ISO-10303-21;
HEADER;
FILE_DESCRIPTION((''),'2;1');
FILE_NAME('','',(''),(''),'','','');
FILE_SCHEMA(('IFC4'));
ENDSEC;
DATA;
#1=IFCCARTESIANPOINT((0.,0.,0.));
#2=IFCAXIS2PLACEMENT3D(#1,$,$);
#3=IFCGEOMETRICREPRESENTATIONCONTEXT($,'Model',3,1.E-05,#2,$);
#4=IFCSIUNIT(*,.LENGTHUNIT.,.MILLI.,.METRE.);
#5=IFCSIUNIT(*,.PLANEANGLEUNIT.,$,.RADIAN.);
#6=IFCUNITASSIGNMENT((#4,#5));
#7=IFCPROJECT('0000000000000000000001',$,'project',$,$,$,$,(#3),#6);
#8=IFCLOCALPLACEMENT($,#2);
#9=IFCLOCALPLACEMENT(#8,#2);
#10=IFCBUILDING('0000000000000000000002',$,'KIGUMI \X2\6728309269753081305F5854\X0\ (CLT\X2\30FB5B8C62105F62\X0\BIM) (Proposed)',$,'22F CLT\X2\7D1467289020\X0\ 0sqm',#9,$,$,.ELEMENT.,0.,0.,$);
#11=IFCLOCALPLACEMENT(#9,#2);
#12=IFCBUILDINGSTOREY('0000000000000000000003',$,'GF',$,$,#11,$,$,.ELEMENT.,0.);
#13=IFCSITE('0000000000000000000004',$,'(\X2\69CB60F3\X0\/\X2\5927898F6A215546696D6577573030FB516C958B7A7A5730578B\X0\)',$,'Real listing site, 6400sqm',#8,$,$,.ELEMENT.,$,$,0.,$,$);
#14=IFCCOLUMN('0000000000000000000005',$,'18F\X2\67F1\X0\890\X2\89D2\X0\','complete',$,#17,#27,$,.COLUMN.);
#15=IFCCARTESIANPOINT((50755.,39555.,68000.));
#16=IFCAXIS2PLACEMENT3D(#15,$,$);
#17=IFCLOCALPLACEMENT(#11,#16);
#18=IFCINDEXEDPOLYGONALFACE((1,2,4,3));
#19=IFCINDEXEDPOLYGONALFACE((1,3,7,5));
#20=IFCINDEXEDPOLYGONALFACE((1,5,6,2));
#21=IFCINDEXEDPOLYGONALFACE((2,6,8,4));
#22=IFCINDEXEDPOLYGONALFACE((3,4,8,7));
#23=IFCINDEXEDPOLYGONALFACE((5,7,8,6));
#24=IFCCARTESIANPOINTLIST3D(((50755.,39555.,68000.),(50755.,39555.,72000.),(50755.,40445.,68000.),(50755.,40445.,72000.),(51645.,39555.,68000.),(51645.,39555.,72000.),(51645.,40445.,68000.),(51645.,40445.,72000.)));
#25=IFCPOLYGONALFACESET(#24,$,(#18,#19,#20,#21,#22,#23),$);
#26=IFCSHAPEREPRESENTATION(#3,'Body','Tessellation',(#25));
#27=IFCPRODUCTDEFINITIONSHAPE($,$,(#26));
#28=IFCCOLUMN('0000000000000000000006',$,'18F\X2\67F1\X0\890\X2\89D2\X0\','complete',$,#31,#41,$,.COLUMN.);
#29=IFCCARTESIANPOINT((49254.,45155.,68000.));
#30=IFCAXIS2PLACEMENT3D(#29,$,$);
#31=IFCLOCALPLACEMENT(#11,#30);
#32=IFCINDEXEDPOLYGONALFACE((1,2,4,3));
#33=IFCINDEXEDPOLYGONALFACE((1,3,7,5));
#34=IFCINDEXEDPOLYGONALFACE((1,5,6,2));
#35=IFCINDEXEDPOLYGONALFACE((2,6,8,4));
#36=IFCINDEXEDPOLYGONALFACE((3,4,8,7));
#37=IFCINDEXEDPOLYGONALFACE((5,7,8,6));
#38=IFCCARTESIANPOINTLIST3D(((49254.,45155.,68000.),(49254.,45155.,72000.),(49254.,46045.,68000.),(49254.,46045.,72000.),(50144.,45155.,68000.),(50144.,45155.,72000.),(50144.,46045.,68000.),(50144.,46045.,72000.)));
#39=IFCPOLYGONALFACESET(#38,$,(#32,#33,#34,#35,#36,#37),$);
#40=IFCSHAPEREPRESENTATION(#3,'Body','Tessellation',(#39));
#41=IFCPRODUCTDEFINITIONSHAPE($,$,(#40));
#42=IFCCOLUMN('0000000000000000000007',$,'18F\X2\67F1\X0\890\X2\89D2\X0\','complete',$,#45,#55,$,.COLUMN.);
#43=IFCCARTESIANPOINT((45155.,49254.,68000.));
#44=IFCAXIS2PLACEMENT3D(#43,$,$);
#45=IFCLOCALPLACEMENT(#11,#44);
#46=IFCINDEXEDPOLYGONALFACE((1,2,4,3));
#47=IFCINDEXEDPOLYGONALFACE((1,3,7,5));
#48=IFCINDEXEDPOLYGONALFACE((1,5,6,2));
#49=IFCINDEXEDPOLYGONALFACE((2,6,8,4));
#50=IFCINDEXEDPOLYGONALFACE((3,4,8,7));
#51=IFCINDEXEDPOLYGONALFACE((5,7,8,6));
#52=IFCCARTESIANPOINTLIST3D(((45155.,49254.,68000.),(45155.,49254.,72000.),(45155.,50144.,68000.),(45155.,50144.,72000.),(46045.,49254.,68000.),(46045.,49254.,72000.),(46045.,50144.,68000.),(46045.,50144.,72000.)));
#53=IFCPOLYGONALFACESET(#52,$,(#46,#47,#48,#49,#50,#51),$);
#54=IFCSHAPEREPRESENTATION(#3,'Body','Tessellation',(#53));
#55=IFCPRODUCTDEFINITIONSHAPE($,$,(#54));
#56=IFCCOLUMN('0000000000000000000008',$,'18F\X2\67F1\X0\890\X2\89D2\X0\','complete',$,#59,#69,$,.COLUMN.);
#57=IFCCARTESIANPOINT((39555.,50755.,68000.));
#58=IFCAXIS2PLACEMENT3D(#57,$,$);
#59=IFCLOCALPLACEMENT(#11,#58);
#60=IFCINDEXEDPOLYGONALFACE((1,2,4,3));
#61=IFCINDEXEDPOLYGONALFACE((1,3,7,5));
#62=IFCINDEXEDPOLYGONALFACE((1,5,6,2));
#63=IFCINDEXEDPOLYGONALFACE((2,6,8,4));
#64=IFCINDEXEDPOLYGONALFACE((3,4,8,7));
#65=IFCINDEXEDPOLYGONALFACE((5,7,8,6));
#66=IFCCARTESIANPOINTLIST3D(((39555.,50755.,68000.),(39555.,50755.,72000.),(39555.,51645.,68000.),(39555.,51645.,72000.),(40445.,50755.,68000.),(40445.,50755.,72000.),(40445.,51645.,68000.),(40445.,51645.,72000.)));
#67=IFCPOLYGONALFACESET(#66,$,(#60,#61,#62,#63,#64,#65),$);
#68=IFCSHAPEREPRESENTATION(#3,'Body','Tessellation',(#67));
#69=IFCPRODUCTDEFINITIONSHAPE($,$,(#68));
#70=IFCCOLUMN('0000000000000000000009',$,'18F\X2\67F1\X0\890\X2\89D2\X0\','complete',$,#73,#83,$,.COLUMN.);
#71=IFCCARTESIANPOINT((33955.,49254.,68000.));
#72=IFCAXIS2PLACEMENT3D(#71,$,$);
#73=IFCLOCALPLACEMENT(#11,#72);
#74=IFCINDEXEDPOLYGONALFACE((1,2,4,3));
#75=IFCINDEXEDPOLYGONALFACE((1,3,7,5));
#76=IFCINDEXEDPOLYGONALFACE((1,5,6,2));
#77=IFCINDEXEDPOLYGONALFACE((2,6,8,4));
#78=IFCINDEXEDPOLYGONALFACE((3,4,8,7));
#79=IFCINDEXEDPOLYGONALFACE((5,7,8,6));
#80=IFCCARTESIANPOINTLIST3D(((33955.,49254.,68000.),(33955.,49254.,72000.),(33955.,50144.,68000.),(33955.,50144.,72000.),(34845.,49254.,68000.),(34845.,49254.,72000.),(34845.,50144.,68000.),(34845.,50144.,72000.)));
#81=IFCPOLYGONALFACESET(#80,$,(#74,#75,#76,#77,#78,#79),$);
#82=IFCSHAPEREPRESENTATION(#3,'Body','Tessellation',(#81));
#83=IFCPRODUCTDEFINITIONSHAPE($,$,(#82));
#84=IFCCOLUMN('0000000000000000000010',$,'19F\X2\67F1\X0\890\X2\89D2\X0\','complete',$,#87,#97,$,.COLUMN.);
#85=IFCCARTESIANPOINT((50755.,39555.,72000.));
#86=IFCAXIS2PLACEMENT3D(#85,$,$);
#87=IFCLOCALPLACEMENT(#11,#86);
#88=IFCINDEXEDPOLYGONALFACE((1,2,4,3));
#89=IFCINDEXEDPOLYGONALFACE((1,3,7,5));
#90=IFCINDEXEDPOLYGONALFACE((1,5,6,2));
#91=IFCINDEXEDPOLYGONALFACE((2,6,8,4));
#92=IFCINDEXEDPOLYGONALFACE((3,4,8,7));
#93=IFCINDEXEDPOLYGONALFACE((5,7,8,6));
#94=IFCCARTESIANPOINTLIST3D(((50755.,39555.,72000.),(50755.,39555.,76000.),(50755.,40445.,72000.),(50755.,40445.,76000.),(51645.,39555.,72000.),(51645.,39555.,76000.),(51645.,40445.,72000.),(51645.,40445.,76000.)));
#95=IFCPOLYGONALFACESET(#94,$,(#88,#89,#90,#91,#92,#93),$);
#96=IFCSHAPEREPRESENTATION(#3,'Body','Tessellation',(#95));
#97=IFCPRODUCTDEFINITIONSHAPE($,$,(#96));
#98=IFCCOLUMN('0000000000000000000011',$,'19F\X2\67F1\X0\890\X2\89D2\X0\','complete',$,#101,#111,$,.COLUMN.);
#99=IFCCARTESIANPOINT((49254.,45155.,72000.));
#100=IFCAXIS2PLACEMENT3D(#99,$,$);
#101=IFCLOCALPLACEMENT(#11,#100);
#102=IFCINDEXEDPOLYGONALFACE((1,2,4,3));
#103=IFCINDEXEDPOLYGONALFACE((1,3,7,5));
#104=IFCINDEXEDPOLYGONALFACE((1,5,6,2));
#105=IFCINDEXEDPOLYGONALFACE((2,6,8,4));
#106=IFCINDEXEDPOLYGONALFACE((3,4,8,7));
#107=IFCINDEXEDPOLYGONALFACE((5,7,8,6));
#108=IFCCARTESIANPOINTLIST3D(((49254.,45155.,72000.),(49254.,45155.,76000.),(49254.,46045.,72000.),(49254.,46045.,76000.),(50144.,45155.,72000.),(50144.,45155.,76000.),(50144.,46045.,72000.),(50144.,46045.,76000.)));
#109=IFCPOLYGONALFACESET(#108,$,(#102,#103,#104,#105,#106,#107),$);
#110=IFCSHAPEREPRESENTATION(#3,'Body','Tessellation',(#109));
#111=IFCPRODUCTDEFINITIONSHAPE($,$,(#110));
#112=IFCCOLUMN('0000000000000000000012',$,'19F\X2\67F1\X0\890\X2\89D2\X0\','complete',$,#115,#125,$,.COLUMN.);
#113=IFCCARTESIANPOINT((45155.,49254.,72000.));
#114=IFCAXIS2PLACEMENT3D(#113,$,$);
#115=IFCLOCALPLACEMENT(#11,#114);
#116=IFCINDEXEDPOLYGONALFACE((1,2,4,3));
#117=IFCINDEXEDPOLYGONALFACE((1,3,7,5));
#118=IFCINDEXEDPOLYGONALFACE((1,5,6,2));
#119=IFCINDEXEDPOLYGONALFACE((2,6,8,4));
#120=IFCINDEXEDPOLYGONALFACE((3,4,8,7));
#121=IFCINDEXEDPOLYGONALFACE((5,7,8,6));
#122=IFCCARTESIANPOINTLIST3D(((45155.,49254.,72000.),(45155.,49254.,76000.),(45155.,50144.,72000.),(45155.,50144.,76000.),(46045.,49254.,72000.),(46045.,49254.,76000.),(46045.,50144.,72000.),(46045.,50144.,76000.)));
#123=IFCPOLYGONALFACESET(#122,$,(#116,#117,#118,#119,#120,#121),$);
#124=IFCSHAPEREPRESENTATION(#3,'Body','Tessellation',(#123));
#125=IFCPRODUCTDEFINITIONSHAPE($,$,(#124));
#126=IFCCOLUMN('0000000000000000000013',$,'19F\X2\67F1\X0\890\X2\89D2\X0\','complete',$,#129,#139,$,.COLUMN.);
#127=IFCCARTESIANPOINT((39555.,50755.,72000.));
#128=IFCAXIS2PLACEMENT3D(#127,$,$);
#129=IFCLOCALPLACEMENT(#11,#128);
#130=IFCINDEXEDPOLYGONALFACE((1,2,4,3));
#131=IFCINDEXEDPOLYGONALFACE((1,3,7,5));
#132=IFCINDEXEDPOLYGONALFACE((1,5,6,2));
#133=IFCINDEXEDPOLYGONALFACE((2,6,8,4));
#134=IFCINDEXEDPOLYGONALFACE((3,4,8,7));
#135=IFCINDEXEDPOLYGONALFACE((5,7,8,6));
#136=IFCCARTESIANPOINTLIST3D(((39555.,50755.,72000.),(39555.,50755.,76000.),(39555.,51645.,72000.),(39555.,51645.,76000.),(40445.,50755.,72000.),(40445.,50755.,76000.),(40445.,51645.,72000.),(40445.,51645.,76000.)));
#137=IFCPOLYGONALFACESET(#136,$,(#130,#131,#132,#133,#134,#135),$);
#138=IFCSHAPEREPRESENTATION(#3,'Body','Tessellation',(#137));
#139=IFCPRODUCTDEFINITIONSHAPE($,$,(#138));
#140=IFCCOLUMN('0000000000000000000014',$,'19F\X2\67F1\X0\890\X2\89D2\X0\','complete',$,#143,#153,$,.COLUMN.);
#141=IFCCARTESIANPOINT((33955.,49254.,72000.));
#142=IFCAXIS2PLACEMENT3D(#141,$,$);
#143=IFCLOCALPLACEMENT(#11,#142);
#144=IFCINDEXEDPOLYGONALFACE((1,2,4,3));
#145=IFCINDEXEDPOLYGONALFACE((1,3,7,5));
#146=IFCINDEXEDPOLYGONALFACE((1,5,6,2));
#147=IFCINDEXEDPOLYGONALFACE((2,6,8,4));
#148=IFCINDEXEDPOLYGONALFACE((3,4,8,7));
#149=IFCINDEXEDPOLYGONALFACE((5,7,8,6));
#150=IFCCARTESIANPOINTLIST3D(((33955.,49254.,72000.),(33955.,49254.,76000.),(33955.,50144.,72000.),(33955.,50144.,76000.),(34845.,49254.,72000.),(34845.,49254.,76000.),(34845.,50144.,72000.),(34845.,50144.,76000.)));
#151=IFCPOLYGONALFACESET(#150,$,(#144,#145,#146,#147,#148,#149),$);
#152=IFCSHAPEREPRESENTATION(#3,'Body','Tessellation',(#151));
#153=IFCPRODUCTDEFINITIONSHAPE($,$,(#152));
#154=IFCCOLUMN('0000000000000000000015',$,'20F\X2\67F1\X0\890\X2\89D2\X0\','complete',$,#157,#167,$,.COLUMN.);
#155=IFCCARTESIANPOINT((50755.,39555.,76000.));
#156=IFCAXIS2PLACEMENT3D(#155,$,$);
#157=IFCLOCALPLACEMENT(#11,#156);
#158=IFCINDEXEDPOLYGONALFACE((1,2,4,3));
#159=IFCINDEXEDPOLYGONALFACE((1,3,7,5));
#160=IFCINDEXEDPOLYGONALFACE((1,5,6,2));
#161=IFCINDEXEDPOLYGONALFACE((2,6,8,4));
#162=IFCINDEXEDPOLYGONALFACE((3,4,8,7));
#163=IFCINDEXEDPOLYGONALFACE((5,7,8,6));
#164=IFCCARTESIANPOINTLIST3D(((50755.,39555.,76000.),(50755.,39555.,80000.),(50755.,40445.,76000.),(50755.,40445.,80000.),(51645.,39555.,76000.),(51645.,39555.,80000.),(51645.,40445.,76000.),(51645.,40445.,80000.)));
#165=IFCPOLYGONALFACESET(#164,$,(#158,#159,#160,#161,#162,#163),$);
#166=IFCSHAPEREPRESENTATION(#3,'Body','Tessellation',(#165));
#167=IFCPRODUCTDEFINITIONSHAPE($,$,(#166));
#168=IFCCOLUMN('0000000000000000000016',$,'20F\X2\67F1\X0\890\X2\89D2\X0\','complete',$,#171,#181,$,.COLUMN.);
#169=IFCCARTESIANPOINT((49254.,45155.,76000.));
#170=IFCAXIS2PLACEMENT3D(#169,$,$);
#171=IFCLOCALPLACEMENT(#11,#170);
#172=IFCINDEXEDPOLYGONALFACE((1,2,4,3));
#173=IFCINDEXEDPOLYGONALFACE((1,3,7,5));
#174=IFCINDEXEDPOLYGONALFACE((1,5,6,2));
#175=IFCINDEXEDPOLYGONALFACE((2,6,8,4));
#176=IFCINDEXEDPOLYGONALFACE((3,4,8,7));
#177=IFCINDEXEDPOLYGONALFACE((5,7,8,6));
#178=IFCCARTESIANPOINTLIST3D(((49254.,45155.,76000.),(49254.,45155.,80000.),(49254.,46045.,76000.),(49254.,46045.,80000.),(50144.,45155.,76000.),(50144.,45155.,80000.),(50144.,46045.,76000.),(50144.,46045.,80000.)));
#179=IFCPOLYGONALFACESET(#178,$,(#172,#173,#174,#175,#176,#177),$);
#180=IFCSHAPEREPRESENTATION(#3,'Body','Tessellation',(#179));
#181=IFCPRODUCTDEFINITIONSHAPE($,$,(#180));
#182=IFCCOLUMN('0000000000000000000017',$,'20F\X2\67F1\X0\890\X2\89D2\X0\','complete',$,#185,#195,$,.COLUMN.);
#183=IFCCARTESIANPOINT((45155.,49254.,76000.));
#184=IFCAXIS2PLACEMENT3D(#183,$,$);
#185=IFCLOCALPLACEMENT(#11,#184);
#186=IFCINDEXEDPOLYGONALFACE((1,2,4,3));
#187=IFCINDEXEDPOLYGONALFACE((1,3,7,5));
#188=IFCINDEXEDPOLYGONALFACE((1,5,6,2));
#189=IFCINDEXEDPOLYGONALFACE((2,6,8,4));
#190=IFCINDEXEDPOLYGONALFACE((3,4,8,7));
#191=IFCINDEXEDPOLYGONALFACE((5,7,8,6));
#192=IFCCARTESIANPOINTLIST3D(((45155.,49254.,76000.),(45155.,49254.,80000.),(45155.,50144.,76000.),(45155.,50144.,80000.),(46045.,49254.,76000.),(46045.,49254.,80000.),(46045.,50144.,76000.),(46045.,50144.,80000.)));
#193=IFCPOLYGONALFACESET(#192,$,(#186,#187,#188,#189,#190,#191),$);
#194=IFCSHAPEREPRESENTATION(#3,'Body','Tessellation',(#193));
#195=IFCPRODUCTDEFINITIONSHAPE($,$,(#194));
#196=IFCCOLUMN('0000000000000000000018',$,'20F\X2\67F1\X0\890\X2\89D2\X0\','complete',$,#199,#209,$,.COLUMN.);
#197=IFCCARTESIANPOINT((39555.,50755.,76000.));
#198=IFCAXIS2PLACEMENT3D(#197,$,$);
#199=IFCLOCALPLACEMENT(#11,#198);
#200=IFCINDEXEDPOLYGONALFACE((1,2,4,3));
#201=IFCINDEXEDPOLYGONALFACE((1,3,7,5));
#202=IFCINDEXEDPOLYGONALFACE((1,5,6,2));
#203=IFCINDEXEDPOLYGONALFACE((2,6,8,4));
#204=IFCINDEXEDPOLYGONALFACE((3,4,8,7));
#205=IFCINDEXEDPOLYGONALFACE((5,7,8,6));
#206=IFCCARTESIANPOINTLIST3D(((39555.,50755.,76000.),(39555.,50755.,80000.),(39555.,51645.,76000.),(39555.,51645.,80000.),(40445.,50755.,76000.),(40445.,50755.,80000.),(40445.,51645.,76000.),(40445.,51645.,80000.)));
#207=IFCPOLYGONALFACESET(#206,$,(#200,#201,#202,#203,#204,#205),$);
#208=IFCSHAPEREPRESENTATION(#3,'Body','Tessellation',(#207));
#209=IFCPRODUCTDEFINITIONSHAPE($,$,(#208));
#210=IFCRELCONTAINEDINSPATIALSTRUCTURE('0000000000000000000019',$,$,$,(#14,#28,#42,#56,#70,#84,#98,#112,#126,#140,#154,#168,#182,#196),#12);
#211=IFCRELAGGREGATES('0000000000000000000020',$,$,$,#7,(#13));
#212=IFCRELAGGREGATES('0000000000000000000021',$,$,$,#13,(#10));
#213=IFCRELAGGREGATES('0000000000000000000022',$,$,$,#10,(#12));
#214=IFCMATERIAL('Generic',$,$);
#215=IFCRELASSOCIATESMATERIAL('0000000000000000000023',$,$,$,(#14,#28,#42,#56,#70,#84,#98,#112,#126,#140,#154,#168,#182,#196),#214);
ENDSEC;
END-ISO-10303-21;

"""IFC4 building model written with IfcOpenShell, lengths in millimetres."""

from ifc_helpers import new_model, si_unit, frame, frame_2d, origin, place, context, project, spatial, rectangle, extrude, material, element, save


model = new_model("IFC4")

# Units and contexts
model_context = context("Model", 3, precision=1e-05, world=origin())
ifc_project = project(units=[si_unit("LENGTHUNIT", "METRE", prefix="MILLI"), si_unit("PLANEANGLEUNIT", "RADIAN")], contexts=[model_context])

# Site, building, storey
site_placement = place(None, origin())
site = spatial("IfcSite", under=ifc_project, at=site_placement, Name="(構想/大規模商業敷地・公開空地型)", ObjectType="Real listing site, 6400sqm", CompositionType="ELEMENT", RefElevation=0.0)
building_placement = place(site_placement, origin())
building = spatial("IfcBuilding", under=site, at=building_placement, Name="KIGUMI 木を極めた塔 (CLT・完成形BIM) (Proposed)", ObjectType="22F CLT純木造 0sqm", CompositionType="ELEMENT", ElevationOfRefHeight=0.0, ElevationOfTerrain=0.0)
storey_placement = place(building_placement, origin())
storey = spatial("IfcBuildingStorey", under=building, at=storey_placement, Name="GF", CompositionType="ELEMENT", Elevation=0.0)

# Columns
ifc_material = material(Name="Generic")
column_1_placement = place(storey_placement, frame((50755.0, 39555.0, 68000.0)))
element("IfcColumn", 1, at=column_1_placement, inside=storey, material=ifc_material, Name="18F柱890角", Description="complete", PredefinedType="COLUMN", context=model_context, shape_type="SweptSolid", body=[
    extrude(rectangle(XDim=890.0, YDim=890.0, at=frame_2d((445.0, 445.0))), frame((50755.0, 39555.0, 68000.0)), (0.0, 0.0, 1.0), 4000.0),
])
column_2_placement = place(storey_placement, frame((49254.0, 45155.0, 68000.0)))
element("IfcColumn", 2, at=column_2_placement, inside=storey, material=ifc_material, Name="18F柱890角", Description="complete", PredefinedType="COLUMN", context=model_context, shape_type="SweptSolid", body=[
    extrude(rectangle(XDim=890.0, YDim=890.0, at=frame_2d((445.0, 445.0))), frame((49254.0, 45155.0, 68000.0)), (0.0, 0.0, 1.0), 4000.0),
])
column_3_placement = place(storey_placement, frame((45155.0, 49254.0, 68000.0)))
element("IfcColumn", 3, at=column_3_placement, inside=storey, material=ifc_material, Name="18F柱890角", Description="complete", PredefinedType="COLUMN", context=model_context, shape_type="SweptSolid", body=[
    extrude(rectangle(XDim=890.0, YDim=890.0, at=frame_2d((445.0, 445.0))), frame((45155.0, 49254.0, 68000.0)), (0.0, 0.0, 1.0), 4000.0),
])
column_4_placement = place(storey_placement, frame((39555.0, 50755.0, 68000.0)))
element("IfcColumn", 4, at=column_4_placement, inside=storey, material=ifc_material, Name="18F柱890角", Description="complete", PredefinedType="COLUMN", context=model_context, shape_type="SweptSolid", body=[
    extrude(rectangle(XDim=890.0, YDim=890.0, at=frame_2d((445.0, 445.0))), frame((39555.0, 50755.0, 68000.0)), (0.0, 0.0, 1.0), 4000.0),
])
column_5_placement = place(storey_placement, frame((33955.0, 49254.0, 68000.0)))
element("IfcColumn", 5, at=column_5_placement, inside=storey, material=ifc_material, Name="18F柱890角", Description="complete", PredefinedType="COLUMN", context=model_context, shape_type="SweptSolid", body=[
    extrude(rectangle(XDim=890.0, YDim=890.0, at=frame_2d((445.0, 445.0))), frame((33955.0, 49254.0, 68000.0)), (0.0, 0.0, 1.0), 4000.0),
])
column_6_placement = place(storey_placement, frame((50755.0, 39555.0, 72000.0)))
element("IfcColumn", 6, at=column_6_placement, inside=storey, material=ifc_material, Name="19F柱890角", Description="complete", PredefinedType="COLUMN", context=model_context, shape_type="SweptSolid", body=[
    extrude(rectangle(XDim=890.0, YDim=890.0, at=frame_2d((445.0, 445.0))), frame((50755.0, 39555.0, 72000.0)), (0.0, 0.0, 1.0), 4000.0),
])
column_7_placement = place(storey_placement, frame((49254.0, 45155.0, 72000.0)))
element("IfcColumn", 7, at=column_7_placement, inside=storey, material=ifc_material, Name="19F柱890角", Description="complete", PredefinedType="COLUMN", context=model_context, shape_type="SweptSolid", body=[
    extrude(rectangle(XDim=890.0, YDim=890.0, at=frame_2d((445.0, 445.0))), frame((49254.0, 45155.0, 72000.0)), (0.0, 0.0, 1.0), 4000.0),
])
column_8_placement = place(storey_placement, frame((45155.0, 49254.0, 72000.0)))
element("IfcColumn", 8, at=column_8_placement, inside=storey, material=ifc_material, Name="19F柱890角", Description="complete", PredefinedType="COLUMN", context=model_context, shape_type="SweptSolid", body=[
    extrude(rectangle(XDim=890.0, YDim=890.0, at=frame_2d((445.0, 445.0))), frame((45155.0, 49254.0, 72000.0)), (0.0, 0.0, 1.0), 4000.0),
])
column_9_placement = place(storey_placement, frame((39555.0, 50755.0, 72000.0)))
element("IfcColumn", 9, at=column_9_placement, inside=storey, material=ifc_material, Name="19F柱890角", Description="complete", PredefinedType="COLUMN", context=model_context, shape_type="SweptSolid", body=[
    extrude(rectangle(XDim=890.0, YDim=890.0, at=frame_2d((445.0, 445.0))), frame((39555.0, 50755.0, 72000.0)), (0.0, 0.0, 1.0), 4000.0),
])
column_10_placement = place(storey_placement, frame((33955.0, 49254.0, 72000.0)))
element("IfcColumn", 10, at=column_10_placement, inside=storey, material=ifc_material, Name="19F柱890角", Description="complete", PredefinedType="COLUMN", context=model_context, shape_type="SweptSolid", body=[
    extrude(rectangle(XDim=890.0, YDim=890.0, at=frame_2d((445.0, 445.0))), frame((33955.0, 49254.0, 72000.0)), (0.0, 0.0, 1.0), 4000.0),
])
column_11_placement = place(storey_placement, frame((50755.0, 39555.0, 76000.0)))
element("IfcColumn", 11, at=column_11_placement, inside=storey, material=ifc_material, Name="20F柱890角", Description="complete", PredefinedType="COLUMN", context=model_context, shape_type="SweptSolid", body=[
    extrude(rectangle(XDim=890.0, YDim=890.0, at=frame_2d((445.0, 445.0))), frame((50755.0, 39555.0, 76000.0)), (0.0, 0.0, 1.0), 4000.0),
])
column_12_placement = place(storey_placement, frame((49254.0, 45155.0, 76000.0)))
element("IfcColumn", 12, at=column_12_placement, inside=storey, material=ifc_material, Name="20F柱890角", Description="complete", PredefinedType="COLUMN", context=model_context, shape_type="SweptSolid", body=[
    extrude(rectangle(XDim=890.0, YDim=890.0, at=frame_2d((445.0, 445.0))), frame((49254.0, 45155.0, 76000.0)), (0.0, 0.0, 1.0), 4000.0),
])
column_13_placement = place(storey_placement, frame((45155.0, 49254.0, 76000.0)))
element("IfcColumn", 13, at=column_13_placement, inside=storey, material=ifc_material, Name="20F柱890角", Description="complete", PredefinedType="COLUMN", context=model_context, shape_type="SweptSolid", body=[
    extrude(rectangle(XDim=890.0, YDim=890.0, at=frame_2d((445.0, 445.0))), frame((45155.0, 49254.0, 76000.0)), (0.0, 0.0, 1.0), 4000.0),
])
column_14_placement = place(storey_placement, frame((39555.0, 50755.0, 76000.0)))
element("IfcColumn", 14, at=column_14_placement, inside=storey, material=ifc_material, Name="20F柱890角", Description="complete", PredefinedType="COLUMN", context=model_context, shape_type="SweptSolid", body=[
    extrude(rectangle(XDim=890.0, YDim=890.0, at=frame_2d((445.0, 445.0))), frame((39555.0, 50755.0, 76000.0)), (0.0, 0.0, 1.0), 4000.0),
])

save(model, "model.ifc")
